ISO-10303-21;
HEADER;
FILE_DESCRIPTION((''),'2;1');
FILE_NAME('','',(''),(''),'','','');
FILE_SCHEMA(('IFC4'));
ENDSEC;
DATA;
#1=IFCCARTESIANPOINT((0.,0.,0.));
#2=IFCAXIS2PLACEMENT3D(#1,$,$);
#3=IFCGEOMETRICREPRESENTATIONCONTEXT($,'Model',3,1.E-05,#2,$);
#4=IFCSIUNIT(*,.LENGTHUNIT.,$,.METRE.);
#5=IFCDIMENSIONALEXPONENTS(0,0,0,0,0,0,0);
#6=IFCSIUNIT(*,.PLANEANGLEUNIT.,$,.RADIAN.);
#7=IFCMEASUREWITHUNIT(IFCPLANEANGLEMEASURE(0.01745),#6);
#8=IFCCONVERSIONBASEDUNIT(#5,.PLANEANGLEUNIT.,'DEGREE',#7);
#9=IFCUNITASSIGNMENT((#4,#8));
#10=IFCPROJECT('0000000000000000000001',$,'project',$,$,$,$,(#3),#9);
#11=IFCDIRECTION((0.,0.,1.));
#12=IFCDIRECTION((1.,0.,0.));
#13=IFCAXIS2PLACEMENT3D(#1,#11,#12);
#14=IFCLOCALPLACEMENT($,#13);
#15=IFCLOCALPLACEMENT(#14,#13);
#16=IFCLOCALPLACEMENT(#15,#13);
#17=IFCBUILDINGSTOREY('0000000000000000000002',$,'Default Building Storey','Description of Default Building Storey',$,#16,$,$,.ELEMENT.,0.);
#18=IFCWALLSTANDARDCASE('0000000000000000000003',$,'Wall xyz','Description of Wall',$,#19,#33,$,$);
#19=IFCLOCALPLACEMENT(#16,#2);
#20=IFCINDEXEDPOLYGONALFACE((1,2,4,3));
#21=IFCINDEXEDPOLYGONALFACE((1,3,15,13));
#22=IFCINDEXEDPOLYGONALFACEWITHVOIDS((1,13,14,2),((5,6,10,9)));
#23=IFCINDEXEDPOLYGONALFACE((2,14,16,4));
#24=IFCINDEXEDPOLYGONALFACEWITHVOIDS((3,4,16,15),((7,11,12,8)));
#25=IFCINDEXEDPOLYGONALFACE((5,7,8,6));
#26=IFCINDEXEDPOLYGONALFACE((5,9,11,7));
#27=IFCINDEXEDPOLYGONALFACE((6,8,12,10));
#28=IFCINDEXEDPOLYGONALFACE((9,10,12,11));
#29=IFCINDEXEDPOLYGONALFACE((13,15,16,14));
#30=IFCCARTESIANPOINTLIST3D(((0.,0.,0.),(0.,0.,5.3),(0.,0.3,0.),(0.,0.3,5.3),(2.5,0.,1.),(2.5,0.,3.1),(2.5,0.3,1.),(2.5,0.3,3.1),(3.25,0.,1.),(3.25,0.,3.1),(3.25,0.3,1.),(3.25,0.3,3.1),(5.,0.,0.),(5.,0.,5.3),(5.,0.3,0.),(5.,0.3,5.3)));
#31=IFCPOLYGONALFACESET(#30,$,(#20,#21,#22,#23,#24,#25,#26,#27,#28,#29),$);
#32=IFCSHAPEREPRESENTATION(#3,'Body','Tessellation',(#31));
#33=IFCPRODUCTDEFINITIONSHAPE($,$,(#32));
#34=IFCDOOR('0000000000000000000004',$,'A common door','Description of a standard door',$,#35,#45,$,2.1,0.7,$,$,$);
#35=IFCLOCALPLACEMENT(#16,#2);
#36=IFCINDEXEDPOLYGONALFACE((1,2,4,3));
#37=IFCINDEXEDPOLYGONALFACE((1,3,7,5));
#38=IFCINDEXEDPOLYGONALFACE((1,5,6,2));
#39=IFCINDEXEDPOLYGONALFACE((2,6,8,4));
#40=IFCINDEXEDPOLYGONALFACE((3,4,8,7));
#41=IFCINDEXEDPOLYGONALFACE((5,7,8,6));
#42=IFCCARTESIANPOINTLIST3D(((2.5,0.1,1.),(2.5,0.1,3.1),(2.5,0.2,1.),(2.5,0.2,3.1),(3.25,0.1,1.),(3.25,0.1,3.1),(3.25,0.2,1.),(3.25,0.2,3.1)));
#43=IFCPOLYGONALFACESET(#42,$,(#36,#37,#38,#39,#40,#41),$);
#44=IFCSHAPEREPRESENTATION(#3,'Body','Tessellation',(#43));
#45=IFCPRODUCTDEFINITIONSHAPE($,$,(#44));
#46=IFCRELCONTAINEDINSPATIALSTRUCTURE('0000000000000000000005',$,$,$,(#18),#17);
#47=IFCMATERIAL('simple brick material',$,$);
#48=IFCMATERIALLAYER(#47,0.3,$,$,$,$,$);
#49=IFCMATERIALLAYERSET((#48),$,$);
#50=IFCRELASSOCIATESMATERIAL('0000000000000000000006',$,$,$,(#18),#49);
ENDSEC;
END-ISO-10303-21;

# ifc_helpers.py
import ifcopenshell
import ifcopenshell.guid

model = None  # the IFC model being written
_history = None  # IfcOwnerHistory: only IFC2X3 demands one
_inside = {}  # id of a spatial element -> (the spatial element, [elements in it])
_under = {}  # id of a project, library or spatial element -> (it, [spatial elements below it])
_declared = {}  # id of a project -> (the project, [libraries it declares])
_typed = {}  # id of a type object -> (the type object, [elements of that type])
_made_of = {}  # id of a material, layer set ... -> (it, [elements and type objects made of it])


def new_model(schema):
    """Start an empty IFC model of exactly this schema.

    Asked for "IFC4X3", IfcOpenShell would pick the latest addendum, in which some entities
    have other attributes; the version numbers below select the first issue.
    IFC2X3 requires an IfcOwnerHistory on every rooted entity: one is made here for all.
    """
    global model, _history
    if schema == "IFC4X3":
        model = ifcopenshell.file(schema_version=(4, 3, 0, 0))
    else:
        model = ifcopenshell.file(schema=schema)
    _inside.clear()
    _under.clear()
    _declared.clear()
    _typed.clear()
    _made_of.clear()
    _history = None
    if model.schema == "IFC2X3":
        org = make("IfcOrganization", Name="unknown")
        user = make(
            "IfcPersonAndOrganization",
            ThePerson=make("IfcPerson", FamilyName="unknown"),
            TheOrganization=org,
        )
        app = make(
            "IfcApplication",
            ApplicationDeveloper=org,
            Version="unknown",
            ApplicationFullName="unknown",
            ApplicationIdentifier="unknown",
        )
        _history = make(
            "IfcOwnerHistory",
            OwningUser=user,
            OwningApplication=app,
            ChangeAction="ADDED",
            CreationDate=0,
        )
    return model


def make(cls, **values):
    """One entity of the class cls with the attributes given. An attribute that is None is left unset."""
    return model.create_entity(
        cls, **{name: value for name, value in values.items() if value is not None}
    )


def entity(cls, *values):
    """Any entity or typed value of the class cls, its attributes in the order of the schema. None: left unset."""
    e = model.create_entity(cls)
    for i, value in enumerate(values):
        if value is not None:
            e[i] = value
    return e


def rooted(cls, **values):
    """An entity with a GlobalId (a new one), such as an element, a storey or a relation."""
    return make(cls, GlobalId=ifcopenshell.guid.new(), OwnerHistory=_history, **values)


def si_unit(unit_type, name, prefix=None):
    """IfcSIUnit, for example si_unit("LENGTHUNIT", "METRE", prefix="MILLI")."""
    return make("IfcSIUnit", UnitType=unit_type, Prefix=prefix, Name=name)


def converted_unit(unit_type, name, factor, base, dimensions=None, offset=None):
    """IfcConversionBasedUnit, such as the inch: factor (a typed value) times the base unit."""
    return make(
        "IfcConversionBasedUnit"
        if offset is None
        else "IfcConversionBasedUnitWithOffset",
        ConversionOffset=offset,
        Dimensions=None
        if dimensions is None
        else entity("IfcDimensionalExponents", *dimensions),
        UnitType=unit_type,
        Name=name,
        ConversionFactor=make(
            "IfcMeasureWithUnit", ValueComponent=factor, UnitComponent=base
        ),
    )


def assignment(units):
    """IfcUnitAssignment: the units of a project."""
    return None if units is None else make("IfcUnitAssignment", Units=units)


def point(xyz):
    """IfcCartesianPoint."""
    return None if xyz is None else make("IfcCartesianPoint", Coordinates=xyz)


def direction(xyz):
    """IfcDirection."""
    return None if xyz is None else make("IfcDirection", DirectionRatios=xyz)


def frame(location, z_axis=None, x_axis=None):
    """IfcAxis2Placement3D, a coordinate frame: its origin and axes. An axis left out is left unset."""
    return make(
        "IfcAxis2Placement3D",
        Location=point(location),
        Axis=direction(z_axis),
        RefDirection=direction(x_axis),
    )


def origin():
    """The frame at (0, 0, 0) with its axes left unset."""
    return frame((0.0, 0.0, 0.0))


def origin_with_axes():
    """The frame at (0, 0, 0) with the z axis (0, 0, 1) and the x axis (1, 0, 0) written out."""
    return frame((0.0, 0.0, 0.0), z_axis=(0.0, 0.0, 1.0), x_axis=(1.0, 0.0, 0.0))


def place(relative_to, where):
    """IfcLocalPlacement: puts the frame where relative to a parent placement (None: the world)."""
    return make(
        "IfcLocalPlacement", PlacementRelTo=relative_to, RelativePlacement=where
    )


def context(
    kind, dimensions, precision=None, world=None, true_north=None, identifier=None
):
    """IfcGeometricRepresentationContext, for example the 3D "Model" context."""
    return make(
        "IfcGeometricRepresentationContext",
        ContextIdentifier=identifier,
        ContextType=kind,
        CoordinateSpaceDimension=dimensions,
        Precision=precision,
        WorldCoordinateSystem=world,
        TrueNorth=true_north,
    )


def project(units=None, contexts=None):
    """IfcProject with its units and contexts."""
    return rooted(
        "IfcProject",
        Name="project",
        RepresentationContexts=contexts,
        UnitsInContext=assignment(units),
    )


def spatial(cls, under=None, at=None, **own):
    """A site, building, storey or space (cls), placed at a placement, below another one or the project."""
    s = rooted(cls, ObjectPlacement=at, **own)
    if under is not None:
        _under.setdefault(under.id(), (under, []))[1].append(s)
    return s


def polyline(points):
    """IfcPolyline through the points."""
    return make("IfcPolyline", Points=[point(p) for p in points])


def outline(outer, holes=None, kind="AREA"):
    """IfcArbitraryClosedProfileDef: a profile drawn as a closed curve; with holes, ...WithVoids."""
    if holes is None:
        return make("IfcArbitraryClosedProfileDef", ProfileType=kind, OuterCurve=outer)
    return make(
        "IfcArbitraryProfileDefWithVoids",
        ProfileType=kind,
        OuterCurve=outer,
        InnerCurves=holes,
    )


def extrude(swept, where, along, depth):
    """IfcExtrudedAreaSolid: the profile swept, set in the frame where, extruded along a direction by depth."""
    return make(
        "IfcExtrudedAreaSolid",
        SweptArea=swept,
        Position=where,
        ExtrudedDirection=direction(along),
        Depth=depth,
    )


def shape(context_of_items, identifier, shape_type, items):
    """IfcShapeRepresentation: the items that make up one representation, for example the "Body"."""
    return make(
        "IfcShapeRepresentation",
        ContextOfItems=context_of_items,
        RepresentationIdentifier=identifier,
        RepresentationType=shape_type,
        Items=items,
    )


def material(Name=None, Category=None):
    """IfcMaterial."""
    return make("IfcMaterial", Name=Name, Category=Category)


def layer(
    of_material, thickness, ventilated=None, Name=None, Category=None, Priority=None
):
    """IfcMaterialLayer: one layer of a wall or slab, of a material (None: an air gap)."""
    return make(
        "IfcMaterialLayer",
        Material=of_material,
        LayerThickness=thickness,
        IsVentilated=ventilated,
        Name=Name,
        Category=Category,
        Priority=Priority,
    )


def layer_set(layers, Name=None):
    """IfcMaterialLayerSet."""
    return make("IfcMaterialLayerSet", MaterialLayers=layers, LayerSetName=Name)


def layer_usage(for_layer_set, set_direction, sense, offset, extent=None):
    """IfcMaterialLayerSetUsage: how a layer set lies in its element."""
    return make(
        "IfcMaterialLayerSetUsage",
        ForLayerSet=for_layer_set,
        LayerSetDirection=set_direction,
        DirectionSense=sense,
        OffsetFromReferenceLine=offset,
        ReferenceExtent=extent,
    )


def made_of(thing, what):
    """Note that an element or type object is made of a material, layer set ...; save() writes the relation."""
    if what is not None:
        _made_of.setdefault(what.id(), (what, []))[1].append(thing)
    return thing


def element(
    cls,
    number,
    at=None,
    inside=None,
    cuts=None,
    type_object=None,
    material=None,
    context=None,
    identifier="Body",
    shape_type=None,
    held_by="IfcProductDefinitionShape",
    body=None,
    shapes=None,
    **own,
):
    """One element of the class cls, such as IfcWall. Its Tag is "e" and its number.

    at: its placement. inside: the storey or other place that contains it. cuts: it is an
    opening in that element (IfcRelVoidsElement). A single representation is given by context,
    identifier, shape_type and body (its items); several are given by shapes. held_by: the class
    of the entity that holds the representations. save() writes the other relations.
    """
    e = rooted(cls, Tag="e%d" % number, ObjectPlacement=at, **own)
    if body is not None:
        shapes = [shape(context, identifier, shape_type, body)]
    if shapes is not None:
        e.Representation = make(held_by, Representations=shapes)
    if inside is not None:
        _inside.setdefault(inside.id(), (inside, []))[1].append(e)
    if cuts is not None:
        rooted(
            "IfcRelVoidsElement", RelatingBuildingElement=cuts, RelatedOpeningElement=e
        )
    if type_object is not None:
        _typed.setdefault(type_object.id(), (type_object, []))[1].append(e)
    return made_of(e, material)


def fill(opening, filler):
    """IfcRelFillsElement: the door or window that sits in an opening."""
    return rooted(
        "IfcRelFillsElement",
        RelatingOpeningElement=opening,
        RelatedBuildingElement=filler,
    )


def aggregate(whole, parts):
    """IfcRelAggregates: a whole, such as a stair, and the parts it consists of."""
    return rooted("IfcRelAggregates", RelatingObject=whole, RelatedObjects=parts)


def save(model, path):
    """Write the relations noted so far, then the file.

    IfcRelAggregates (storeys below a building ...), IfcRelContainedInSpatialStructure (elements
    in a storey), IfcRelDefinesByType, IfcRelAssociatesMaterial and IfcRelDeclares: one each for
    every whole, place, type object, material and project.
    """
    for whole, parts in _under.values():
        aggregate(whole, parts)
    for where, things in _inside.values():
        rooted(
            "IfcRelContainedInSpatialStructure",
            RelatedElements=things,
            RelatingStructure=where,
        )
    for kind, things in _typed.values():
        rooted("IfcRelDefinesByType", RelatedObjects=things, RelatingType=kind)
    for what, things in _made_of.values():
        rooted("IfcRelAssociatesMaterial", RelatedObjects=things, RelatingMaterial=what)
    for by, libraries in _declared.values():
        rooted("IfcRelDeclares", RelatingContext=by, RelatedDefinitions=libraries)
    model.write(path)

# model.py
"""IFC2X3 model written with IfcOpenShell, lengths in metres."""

from ifc_helpers import new_model, entity, si_unit, converted_unit, frame, origin, origin_with_axes, place, context, project, spatial, polyline, outline, extrude, material, layer, layer_set, layer_usage, element, fill, save


model = new_model("IFC2X3")

# Units and contexts
model_context = context("Model", 3, precision=1e-05, world=origin())
ifc_project = project(units=[si_unit("LENGTHUNIT", "METRE"), converted_unit("PLANEANGLEUNIT", "DEGREE", entity("IfcPlaneAngleMeasure", 0.01745), si_unit("PLANEANGLEUNIT", "RADIAN"), dimensions=[0, 0, 0, 0, 0, 0, 0])], contexts=[model_context])

# Storey
placement_1 = place(None, origin_with_axes())
placement_2 = place(placement_1, origin_with_axes())
storey_placement = place(placement_2, origin_with_axes())
storey = spatial("IfcBuildingStorey", at=storey_placement, Name="Default Building Storey", Description="Description of Default Building Storey", CompositionType="ELEMENT", Elevation=0.0)

# Wall, opening, door
ifc_material = material(Name="simple brick material")
ifc_layer = layer(ifc_material, 0.3)
ifc_layer_set = layer_set([ifc_layer])
ifc_layer_usage = layer_usage(ifc_layer_set, "AXIS2", "POSITIVE", -0.15)
wall_placement = place(storey_placement, origin_with_axes())
wall = element("IfcWallStandardCase", 1, at=wall_placement, inside=storey, material=ifc_layer_usage, Name="Wall xyz", Description="Description of Wall", context=model_context, shape_type="SweptSolid", body=[
    extrude(outline(polyline([(0.0, 0.0), (0.0, 0.3), (5.0, 0.3), (5.0, 0.0), (0.0, 0.0)])), origin_with_axes(), (0.0, 0.0, 1.0), 5.3),
])
opening_placement = place(wall_placement, frame((2.5, 0.0, 1.0), z_axis=(0.0, 0.0, 1.0), x_axis=(1.0, 0.0, 0.0)))
opening = element("IfcOpeningElement", 2, at=opening_placement, inside=storey, cuts=wall, context=model_context, shape_type="SweptSolid", body=[
    extrude(outline(polyline([(0.0, 0.0), (0.0, 0.3), (0.75, 0.3), (0.75, 0.0), (0.0, 0.0)])), origin_with_axes(), (0.0, 0.0, 1.0), 2.1),
])
door_placement = place(opening_placement, frame((0.0, 0.1, 0.0), z_axis=(0.0, 0.0, 1.0), x_axis=(1.0, 0.0, 0.0)))
door = element("IfcDoor", 3, at=door_placement, Name="A common door", Description="Description of a standard door", OverallHeight=2.1, OverallWidth=0.7, context=model_context, shape_type="SweptSolid", body=[
    extrude(outline(polyline([(0.0, 0.0), (0.0, 0.1), (0.75, 0.1), (0.75, 0.0), (0.0, 0.0)])), origin_with_axes(), (0.0, 0.0, 1.0), 2.1),
])
fill(opening, door)

save(model, "model.ifc")
